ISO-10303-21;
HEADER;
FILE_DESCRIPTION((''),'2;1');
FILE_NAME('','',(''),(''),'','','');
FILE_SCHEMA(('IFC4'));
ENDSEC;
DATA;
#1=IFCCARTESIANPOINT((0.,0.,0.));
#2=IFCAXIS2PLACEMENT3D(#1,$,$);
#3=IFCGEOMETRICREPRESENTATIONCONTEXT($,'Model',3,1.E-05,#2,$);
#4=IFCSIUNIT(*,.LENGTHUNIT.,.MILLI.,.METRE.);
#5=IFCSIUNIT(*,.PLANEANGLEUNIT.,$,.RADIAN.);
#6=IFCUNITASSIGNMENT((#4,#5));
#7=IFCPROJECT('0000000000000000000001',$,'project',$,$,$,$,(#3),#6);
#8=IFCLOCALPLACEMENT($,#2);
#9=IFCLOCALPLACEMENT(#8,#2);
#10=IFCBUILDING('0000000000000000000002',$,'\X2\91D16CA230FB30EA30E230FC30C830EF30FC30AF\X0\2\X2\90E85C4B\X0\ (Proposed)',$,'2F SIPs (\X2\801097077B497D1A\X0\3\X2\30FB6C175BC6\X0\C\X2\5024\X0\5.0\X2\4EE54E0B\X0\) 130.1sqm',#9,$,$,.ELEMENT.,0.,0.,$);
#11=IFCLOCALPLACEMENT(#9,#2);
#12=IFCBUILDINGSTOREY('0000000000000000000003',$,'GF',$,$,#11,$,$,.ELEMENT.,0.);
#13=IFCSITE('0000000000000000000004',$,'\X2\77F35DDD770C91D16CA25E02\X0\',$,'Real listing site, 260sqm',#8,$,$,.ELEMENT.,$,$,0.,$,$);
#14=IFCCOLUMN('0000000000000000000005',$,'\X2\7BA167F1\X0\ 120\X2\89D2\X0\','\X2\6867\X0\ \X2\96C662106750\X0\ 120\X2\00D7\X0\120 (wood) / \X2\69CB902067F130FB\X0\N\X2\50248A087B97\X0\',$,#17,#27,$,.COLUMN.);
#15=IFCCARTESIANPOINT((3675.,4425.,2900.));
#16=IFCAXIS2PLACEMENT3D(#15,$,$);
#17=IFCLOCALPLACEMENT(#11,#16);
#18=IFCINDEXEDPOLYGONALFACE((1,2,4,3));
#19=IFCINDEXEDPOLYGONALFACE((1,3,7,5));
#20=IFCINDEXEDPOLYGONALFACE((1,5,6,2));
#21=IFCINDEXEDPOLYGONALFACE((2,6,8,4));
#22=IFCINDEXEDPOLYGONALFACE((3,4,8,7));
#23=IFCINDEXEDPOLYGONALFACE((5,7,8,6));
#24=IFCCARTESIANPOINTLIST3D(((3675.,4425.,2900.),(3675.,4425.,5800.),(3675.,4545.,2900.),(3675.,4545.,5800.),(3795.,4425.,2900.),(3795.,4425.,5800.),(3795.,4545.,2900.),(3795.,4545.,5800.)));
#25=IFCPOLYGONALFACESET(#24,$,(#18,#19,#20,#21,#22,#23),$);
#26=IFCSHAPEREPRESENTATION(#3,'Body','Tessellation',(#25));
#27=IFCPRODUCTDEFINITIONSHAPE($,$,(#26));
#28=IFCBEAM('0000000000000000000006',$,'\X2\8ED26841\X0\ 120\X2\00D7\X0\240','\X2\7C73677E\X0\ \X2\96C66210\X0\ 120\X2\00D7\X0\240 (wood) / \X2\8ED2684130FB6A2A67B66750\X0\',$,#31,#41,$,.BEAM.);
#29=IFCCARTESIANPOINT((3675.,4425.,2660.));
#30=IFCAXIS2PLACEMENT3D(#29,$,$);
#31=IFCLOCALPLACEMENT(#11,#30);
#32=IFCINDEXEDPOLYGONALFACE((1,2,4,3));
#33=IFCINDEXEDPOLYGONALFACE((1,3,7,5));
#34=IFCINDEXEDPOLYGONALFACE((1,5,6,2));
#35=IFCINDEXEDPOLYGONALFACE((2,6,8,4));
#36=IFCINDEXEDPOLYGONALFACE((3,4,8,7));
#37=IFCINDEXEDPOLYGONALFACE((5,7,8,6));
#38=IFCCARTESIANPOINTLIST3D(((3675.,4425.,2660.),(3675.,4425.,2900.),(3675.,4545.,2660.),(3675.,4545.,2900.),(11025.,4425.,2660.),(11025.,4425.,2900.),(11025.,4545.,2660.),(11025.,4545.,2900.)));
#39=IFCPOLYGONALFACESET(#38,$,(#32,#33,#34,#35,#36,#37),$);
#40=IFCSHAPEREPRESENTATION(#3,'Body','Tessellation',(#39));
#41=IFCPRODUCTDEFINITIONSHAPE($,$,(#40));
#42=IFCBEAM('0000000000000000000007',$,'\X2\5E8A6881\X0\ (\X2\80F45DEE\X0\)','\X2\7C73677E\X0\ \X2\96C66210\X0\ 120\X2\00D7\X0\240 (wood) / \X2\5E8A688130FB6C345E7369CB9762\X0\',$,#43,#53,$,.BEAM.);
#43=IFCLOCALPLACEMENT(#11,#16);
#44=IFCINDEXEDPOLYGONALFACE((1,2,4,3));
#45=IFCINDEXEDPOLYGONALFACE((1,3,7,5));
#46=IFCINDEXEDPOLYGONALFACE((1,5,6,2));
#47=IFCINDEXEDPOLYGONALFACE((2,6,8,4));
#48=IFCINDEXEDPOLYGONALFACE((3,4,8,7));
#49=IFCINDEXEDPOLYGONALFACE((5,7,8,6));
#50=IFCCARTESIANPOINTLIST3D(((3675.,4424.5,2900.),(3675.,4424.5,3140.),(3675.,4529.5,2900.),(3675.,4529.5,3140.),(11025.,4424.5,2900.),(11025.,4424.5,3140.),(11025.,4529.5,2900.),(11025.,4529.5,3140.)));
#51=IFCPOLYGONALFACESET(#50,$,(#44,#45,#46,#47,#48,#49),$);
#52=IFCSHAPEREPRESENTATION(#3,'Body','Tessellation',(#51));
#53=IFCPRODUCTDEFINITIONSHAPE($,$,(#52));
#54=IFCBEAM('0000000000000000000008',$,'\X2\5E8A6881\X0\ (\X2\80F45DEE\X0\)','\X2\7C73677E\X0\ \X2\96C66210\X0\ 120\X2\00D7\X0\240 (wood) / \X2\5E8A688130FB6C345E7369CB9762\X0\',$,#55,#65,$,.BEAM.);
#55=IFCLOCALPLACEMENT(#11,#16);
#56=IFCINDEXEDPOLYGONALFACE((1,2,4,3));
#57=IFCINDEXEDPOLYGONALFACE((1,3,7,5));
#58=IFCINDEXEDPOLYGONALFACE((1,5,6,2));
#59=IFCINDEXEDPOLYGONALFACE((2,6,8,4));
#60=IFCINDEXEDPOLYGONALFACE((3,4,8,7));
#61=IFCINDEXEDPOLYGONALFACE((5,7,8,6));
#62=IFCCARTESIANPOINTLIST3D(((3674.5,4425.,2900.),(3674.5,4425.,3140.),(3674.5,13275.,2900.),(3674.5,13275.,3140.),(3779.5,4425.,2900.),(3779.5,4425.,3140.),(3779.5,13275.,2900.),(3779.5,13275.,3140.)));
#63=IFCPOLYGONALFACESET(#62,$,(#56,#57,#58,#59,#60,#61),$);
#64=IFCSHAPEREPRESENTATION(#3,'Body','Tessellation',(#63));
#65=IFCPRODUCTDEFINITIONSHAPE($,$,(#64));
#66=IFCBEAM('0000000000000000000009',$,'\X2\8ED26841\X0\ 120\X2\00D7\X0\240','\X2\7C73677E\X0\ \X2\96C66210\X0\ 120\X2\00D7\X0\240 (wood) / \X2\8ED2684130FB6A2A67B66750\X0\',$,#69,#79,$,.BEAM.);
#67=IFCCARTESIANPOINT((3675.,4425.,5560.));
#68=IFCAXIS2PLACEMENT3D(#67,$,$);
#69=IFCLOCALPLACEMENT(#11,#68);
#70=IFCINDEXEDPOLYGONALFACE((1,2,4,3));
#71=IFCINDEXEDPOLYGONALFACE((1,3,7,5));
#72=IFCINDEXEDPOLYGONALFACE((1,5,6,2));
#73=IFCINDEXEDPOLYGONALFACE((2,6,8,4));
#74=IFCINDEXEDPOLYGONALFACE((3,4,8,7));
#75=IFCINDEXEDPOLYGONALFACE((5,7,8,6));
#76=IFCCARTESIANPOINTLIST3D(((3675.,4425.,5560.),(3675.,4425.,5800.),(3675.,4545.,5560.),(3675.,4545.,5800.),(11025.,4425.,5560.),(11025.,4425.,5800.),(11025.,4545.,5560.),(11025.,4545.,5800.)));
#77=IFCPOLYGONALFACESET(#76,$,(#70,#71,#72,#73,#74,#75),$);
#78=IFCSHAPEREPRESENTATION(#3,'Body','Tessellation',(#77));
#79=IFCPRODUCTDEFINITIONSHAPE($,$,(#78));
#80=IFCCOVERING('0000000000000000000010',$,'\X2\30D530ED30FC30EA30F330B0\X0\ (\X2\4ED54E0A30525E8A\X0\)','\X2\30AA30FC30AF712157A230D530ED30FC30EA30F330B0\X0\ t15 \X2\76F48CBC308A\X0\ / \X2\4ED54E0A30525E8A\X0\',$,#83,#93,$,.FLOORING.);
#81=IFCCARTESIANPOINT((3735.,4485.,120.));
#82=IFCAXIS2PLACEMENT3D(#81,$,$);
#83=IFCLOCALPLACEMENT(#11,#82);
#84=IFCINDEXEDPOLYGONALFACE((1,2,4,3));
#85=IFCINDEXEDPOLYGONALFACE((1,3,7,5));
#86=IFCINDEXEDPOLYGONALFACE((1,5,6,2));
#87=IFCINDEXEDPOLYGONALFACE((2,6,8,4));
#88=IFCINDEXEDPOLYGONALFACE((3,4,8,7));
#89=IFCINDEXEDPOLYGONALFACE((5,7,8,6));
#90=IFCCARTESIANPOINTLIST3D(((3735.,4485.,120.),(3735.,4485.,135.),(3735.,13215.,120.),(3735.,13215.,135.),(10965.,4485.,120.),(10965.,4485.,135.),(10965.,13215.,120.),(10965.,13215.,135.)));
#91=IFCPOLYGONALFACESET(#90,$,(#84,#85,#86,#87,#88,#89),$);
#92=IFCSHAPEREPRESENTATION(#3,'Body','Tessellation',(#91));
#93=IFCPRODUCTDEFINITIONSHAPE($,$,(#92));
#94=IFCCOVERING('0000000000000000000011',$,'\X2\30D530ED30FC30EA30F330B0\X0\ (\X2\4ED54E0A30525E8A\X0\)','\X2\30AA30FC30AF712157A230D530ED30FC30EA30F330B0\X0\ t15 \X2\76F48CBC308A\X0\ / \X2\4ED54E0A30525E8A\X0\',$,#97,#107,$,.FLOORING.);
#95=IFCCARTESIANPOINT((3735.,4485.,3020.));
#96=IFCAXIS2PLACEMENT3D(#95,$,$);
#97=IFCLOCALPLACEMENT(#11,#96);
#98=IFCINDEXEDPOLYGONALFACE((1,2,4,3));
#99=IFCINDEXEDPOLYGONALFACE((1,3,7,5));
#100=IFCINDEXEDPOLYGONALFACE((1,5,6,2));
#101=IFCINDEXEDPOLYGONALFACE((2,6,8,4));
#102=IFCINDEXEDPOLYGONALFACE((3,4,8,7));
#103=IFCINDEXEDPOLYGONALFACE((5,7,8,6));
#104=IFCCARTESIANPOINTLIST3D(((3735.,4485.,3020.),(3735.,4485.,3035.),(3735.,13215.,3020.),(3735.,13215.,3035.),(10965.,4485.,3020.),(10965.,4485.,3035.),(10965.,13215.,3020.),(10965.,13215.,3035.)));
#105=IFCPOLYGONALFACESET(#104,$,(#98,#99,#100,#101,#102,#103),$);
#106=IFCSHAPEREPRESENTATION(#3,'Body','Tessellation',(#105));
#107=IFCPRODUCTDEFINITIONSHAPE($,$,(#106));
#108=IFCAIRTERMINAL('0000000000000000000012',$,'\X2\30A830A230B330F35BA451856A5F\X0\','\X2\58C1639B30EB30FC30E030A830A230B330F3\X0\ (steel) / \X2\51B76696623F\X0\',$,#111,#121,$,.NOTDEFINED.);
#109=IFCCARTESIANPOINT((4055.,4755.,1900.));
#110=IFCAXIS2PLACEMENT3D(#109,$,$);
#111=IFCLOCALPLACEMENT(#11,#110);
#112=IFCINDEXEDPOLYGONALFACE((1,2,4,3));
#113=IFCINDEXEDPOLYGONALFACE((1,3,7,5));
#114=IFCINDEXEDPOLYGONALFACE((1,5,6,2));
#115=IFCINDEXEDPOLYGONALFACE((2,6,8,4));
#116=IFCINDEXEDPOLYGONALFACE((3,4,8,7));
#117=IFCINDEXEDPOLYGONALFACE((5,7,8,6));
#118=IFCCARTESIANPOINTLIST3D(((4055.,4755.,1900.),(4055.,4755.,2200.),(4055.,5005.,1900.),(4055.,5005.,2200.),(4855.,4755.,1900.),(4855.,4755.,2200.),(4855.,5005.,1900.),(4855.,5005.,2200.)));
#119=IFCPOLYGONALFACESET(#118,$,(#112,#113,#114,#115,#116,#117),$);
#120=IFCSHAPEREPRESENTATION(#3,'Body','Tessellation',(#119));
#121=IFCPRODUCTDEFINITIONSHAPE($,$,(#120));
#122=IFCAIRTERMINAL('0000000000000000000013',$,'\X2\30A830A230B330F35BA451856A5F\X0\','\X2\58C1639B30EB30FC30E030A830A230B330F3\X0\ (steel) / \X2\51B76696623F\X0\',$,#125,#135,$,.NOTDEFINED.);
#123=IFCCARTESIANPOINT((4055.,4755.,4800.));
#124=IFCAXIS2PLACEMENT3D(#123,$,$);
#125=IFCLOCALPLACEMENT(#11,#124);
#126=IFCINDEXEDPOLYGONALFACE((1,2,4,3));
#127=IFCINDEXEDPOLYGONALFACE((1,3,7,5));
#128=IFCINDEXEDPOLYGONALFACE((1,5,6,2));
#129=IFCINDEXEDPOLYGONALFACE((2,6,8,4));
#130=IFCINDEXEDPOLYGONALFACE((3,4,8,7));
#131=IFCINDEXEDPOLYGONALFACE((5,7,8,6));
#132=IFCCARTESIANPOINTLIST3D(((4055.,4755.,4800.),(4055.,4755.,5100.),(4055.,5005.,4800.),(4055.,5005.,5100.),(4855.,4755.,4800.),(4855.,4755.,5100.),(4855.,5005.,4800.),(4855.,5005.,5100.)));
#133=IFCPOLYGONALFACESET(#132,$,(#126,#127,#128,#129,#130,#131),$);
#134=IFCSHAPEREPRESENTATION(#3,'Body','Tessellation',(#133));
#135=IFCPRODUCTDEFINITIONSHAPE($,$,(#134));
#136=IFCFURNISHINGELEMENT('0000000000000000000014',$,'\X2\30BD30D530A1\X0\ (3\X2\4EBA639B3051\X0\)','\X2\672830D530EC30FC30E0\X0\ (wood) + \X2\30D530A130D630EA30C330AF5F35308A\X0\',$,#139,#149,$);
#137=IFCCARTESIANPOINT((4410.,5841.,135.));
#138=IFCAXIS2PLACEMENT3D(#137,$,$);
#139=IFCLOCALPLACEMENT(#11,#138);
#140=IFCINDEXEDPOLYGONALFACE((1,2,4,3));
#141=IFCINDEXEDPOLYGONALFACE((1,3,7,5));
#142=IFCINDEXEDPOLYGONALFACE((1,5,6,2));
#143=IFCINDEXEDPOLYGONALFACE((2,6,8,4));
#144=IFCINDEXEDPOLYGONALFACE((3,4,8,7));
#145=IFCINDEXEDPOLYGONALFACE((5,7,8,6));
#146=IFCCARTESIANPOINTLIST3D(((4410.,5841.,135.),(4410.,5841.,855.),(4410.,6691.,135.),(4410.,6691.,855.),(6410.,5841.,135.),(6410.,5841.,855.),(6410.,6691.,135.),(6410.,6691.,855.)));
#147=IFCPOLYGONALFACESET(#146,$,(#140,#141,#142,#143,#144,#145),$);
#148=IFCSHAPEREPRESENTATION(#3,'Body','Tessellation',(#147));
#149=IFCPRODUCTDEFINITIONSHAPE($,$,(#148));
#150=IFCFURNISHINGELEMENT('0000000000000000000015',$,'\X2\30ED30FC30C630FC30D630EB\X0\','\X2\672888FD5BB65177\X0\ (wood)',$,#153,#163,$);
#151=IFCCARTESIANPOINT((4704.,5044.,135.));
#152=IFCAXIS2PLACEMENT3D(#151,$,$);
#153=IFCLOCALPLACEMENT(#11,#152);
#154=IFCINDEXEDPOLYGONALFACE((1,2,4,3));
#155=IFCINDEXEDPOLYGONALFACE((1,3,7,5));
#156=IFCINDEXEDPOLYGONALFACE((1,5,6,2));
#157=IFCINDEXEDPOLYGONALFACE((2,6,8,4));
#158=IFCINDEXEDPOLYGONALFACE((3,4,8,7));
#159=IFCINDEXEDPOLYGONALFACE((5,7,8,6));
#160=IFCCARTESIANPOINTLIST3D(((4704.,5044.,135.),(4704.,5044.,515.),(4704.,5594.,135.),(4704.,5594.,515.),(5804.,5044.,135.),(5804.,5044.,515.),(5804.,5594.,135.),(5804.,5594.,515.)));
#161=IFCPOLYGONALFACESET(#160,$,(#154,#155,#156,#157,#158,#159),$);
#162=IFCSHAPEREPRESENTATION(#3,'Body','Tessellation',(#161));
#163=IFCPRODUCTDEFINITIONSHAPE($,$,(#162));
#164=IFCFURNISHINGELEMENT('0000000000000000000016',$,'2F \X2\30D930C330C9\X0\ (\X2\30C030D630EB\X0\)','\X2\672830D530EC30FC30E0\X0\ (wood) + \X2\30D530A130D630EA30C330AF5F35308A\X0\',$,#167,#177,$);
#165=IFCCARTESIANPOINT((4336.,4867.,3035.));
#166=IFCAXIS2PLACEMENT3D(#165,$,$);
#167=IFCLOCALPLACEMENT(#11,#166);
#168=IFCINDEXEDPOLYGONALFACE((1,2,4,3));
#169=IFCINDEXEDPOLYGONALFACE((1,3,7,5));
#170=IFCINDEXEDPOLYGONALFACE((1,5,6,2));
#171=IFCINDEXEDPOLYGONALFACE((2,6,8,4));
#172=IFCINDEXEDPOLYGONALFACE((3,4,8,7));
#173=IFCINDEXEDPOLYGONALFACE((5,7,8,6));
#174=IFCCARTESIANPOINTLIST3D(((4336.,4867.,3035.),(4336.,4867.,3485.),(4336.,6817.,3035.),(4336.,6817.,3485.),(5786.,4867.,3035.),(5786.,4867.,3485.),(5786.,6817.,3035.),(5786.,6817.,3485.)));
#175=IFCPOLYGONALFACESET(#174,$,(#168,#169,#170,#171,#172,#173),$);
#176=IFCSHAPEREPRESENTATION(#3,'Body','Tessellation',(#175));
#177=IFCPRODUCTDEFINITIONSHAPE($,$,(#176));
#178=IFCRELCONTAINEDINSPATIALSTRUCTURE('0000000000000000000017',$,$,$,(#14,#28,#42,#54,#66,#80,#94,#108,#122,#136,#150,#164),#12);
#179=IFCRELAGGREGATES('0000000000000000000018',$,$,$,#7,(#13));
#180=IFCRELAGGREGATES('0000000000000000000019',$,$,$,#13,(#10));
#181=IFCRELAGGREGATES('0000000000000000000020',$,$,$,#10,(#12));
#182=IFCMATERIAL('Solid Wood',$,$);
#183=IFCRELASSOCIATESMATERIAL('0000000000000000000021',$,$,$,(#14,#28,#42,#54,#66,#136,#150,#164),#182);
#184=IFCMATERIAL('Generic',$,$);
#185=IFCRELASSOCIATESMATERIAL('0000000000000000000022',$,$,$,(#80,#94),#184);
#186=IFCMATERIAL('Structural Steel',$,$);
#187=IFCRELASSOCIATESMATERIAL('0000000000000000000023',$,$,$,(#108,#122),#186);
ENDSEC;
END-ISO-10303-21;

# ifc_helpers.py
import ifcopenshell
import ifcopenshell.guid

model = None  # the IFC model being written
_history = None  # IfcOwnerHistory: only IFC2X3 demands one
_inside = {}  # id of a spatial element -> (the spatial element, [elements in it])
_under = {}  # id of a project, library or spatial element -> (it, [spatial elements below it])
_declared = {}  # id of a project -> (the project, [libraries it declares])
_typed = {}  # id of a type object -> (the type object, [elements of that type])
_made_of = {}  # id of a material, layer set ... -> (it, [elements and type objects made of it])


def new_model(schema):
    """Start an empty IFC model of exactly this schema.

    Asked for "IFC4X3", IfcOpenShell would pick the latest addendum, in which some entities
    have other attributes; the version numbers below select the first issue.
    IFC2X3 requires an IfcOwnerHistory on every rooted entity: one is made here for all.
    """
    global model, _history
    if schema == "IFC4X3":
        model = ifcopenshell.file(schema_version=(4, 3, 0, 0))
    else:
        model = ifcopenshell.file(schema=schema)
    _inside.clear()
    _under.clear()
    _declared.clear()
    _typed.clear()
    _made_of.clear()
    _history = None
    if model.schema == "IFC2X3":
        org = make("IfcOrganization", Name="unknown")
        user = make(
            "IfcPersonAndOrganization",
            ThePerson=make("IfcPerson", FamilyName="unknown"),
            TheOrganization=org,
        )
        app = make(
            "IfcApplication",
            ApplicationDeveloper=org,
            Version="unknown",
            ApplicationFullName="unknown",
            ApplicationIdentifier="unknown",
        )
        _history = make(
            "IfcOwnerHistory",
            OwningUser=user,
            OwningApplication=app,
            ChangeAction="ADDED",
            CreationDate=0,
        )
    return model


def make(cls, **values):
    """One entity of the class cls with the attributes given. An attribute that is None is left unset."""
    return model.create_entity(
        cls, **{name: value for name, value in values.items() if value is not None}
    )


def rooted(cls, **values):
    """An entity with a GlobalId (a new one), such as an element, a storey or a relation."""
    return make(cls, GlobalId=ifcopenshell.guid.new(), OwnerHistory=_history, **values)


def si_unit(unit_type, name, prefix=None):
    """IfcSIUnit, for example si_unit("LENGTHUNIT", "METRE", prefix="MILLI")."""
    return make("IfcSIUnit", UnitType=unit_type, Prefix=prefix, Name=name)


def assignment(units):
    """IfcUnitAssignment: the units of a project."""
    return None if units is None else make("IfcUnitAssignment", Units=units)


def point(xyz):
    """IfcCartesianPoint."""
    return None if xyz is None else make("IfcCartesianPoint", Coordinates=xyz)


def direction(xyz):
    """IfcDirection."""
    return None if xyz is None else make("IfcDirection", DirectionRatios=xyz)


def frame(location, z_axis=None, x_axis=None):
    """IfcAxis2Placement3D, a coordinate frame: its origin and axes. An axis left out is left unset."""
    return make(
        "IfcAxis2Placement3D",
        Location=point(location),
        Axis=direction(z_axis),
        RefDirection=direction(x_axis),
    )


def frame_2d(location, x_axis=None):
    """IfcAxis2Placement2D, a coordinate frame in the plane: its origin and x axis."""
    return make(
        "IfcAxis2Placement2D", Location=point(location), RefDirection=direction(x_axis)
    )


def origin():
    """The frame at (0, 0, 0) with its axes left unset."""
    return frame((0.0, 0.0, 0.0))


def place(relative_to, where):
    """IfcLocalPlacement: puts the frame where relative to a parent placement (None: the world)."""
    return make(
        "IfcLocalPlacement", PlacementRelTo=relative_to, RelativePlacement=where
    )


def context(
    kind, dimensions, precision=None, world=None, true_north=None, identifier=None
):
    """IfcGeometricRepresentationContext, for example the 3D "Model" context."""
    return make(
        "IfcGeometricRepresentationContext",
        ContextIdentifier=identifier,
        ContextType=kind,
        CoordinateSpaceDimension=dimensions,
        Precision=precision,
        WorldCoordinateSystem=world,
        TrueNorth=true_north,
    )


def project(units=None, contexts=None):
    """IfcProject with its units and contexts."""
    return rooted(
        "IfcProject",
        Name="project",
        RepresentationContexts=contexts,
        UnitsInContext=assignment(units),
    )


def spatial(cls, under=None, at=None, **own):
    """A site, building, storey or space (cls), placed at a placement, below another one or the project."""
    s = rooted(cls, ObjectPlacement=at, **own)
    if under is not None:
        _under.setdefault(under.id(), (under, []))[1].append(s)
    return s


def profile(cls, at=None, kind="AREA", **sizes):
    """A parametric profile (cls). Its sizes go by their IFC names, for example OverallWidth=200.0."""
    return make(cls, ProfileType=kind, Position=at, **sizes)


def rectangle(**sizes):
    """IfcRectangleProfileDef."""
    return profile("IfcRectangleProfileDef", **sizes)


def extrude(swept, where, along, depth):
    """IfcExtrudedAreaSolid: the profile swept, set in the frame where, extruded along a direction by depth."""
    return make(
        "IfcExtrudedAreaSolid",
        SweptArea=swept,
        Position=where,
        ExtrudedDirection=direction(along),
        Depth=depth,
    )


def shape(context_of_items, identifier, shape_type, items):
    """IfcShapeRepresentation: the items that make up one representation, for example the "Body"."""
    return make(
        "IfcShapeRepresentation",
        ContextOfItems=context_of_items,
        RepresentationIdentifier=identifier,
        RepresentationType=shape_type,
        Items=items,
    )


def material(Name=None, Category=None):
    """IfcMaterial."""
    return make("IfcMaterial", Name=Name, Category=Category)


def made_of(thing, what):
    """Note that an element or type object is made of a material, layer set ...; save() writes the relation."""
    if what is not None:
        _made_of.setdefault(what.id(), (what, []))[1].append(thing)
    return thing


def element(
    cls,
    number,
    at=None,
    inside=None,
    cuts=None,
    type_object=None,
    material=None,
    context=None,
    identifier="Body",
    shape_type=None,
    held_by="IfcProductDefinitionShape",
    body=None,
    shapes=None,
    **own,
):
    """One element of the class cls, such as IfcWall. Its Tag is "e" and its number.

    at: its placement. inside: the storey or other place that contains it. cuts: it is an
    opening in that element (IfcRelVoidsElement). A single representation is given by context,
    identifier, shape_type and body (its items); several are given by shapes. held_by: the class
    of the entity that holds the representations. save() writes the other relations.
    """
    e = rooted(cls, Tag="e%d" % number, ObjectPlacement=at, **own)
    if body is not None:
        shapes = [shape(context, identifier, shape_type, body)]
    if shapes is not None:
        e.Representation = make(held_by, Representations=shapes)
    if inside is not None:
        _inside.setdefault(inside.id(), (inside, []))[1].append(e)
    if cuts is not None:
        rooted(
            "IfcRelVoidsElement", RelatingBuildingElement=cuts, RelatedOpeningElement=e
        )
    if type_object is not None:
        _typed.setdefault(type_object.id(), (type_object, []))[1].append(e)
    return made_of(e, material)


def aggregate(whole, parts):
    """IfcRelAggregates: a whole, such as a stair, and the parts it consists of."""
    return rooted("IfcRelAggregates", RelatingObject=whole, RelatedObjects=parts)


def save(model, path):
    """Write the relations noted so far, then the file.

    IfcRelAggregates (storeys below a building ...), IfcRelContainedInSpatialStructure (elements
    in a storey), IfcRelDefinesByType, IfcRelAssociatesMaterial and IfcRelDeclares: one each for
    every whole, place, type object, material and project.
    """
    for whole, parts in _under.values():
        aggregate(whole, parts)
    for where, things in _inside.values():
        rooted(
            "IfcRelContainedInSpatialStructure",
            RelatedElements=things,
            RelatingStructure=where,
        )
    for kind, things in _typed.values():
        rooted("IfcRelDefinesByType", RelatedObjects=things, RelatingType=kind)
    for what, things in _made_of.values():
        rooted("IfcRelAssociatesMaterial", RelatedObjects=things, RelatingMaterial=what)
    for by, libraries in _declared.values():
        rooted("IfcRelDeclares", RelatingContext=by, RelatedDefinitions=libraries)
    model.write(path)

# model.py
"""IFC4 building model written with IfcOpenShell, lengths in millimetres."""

from ifc_helpers import new_model, si_unit, frame, frame_2d, origin, place, context, project, spatial, rectangle, extrude, material, element, save


model = new_model("IFC4")

# Units and contexts
model_context = context("Model", 3, precision=1e-05, world=origin())
ifc_project = project(units=[si_unit("LENGTHUNIT", "METRE", prefix="MILLI"), si_unit("PLANEANGLEUNIT", "RADIAN")], contexts=[model_context])

# Site, building, storey
site_placement = place(None, origin())
site = spatial("IfcSite", under=ifc_project, at=site_placement, Name="石川県金沢市", ObjectType="Real listing site, 260sqm", CompositionType="ELEMENT", RefElevation=0.0)
building_placement = place(site_placement, origin())
building = spatial("IfcBuilding", under=site, at=building_placement, Name="金沢・リモートワーク2部屋 (Proposed)", ObjectType="2F SIPs (耐震等級3・気密C値5.0以下) 130.1sqm", CompositionType="ELEMENT", ElevationOfRefHeight=0.0, ElevationOfTerrain=0.0)
storey_placement = place(building_placement, origin())
storey = spatial("IfcBuildingStorey", under=building, at=storey_placement, Name="GF", CompositionType="ELEMENT", Elevation=0.0)

# Column
ifc_material_1 = material(Name="Solid Wood")
column_placement = place(storey_placement, frame((3675.0, 4425.0, 2900.0)))
element("IfcColumn", 1, at=column_placement, inside=storey, material=ifc_material_1, Name="管柱 120角", Description="桧 集成材 120×120 (wood) / 構造柱・N値計算", PredefinedType="COLUMN", context=model_context, shape_type="SweptSolid", body=[
    extrude(rectangle(XDim=120.0, YDim=120.0, at=frame_2d((60.0, 60.0))), frame((3675.0, 4425.0, 2900.0)), (0.0, 0.0, 1.0), 2900.0),
])

# Beams
beam_1_placement = place(storey_placement, frame((3675.0, 4425.0, 2660.0)))
element("IfcBeam", 2, at=beam_1_placement, inside=storey, material=ifc_material_1, Name="軒桁 120×240", Description="米松 集成 120×240 (wood) / 軒桁・横架材", PredefinedType="BEAM", context=model_context, shape_type="SweptSolid", body=[
    extrude(rectangle(XDim=7350.0, YDim=120.0, at=frame_2d((3675.0, 60.0))), frame((3675.0, 4425.0, 2660.0)), (0.0, 0.0, 1.0), 240.0),
])
beam_2_placement = place(storey_placement, frame((3675.0, 4425.0, 2900.0)))
element("IfcBeam", 3, at=beam_2_placement, inside=storey, material=ifc_material_1, Name="床梁 (胴差)", Description="米松 集成 120×240 (wood) / 床梁・水平構面", PredefinedType="BEAM", context=model_context, shape_type="SweptSolid", body=[
    extrude(rectangle(XDim=7350.0, YDim=105.0, at=frame_2d((3675.0, 52.0))), frame((3675.0, 4425.0, 2900.0)), (0.0, 0.0, 1.0), 240.0),
])
beam_3_placement = place(storey_placement, frame((3675.0, 4425.0, 2900.0)))
element("IfcBeam", 4, at=beam_3_placement, inside=storey, material=ifc_material_1, Name="床梁 (胴差)", Description="米松 集成 120×240 (wood) / 床梁・水平構面", PredefinedType="BEAM", context=model_context, shape_type="SweptSolid", body=[
    extrude(rectangle(XDim=105.0, YDim=8850.0, at=frame_2d((52.0, 4425.0))), frame((3675.0, 4425.0, 2900.0)), (0.0, 0.0, 1.0), 240.0),
])
beam_4_placement = place(storey_placement, frame((3675.0, 4425.0, 5560.0)))
element("IfcBeam", 5, at=beam_4_placement, inside=storey, material=ifc_material_1, Name="軒桁 120×240", Description="米松 集成 120×240 (wood) / 軒桁・横架材", PredefinedType="BEAM", context=model_context, shape_type="SweptSolid", body=[
    extrude(rectangle(XDim=7350.0, YDim=120.0, at=frame_2d((3675.0, 60.0))), frame((3675.0, 4425.0, 5560.0)), (0.0, 0.0, 1.0), 240.0),
])

# Coverings
ifc_material_2 = material(Name="Generic")
covering_1_placement = place(storey_placement, frame((3735.0, 4485.0, 120.0)))
element("IfcCovering", 6, at=covering_1_placement, inside=storey, material=ifc_material_2, Name="フローリング (仕上げ床)", Description="オーク無垢フローリング t15 直貼り / 仕上げ床", PredefinedType="FLOORING", context=model_context, shape_type="SweptSolid", body=[
    extrude(rectangle(XDim=7230.0, YDim=8730.0, at=frame_2d((3615.0, 4365.0))), frame((3735.0, 4485.0, 120.0)), (0.0, 0.0, 1.0), 15.0),
])
covering_2_placement = place(storey_placement, frame((3735.0, 4485.0, 3020.0)))
element("IfcCovering", 7, at=covering_2_placement, inside=storey, material=ifc_material_2, Name="フローリング (仕上げ床)", Description="オーク無垢フローリング t15 直貼り / 仕上げ床", PredefinedType="FLOORING", context=model_context, shape_type="SweptSolid", body=[
    extrude(rectangle(XDim=7230.0, YDim=8730.0, at=frame_2d((3615.0, 4365.0))), frame((3735.0, 4485.0, 3020.0)), (0.0, 0.0, 1.0), 15.0),
])

# Air terminals
ifc_material_3 = material(Name="Structural Steel")
air_terminal_1_placement = place(storey_placement, frame((4055.0, 4755.0, 1900.0)))
element("IfcAirTerminal", 8, at=air_terminal_1_placement, inside=storey, material=ifc_material_3, Name="エアコン室内機", Description="壁掛ルームエアコン (steel) / 冷暖房", PredefinedType="NOTDEFINED", context=model_context, shape_type="SweptSolid", body=[
    extrude(rectangle(XDim=800.0, YDim=250.0, at=frame_2d((400.0, 125.0))), frame((4055.0, 4755.0, 1900.0)), (0.0, 0.0, 1.0), 300.0),
])
air_terminal_2_placement = place(storey_placement, frame((4055.0, 4755.0, 4800.0)))
element("IfcAirTerminal", 9, at=air_terminal_2_placement, inside=storey, material=ifc_material_3, Name="エアコン室内機", Description="壁掛ルームエアコン (steel) / 冷暖房", PredefinedType="NOTDEFINED", context=model_context, shape_type="SweptSolid", body=[
    extrude(rectangle(XDim=800.0, YDim=250.0, at=frame_2d((400.0, 125.0))), frame((4055.0, 4755.0, 4800.0)), (0.0, 0.0, 1.0), 300.0),
])

# Furnishing elements
furnishing_1_placement = place(storey_placement, frame((4410.0, 5841.0, 135.0)))
element("IfcFurnishingElement", 10, at=furnishing_1_placement, inside=storey, material=ifc_material_1, Name="ソファ (3人掛け)", Description="木フレーム (wood) + ファブリック張り", context=model_context, shape_type="SweptSolid", body=[
    extrude(rectangle(XDim=2000.0, YDim=850.0, at=frame_2d((1000.0, 425.0))), frame((4410.0, 5841.0, 135.0)), (0.0, 0.0, 1.0), 720.0),
])
furnishing_2_placement = place(storey_placement, frame((4704.0, 5044.0, 135.0)))
element("IfcFurnishingElement", 11, at=furnishing_2_placement, inside=storey, material=ifc_material_1, Name="ローテーブル", Description="木製家具 (wood)", context=model_context, shape_type="SweptSolid", body=[
    extrude(rectangle(XDim=1100.0, YDim=550.0, at=frame_2d((550.0, 275.0))), frame((4704.0, 5044.0, 135.0)), (0.0, 0.0, 1.0), 380.0),
])
furnishing_3_placement = place(storey_placement, frame((4336.0, 4867.0, 3035.0)))
element("IfcFurnishingElement", 12, at=furnishing_3_placement, inside=storey, material=ifc_material_1, Name="2F ベッド (ダブル)", Description="木フレーム (wood) + ファブリック張り", context=model_context, shape_type="SweptSolid", body=[
    extrude(rectangle(XDim=1450.0, YDim=1950.0, at=frame_2d((725.0, 975.0))), frame((4336.0, 4867.0, 3035.0)), (0.0, 0.0, 1.0), 450.0),
])

save(model, "model.ifc")
